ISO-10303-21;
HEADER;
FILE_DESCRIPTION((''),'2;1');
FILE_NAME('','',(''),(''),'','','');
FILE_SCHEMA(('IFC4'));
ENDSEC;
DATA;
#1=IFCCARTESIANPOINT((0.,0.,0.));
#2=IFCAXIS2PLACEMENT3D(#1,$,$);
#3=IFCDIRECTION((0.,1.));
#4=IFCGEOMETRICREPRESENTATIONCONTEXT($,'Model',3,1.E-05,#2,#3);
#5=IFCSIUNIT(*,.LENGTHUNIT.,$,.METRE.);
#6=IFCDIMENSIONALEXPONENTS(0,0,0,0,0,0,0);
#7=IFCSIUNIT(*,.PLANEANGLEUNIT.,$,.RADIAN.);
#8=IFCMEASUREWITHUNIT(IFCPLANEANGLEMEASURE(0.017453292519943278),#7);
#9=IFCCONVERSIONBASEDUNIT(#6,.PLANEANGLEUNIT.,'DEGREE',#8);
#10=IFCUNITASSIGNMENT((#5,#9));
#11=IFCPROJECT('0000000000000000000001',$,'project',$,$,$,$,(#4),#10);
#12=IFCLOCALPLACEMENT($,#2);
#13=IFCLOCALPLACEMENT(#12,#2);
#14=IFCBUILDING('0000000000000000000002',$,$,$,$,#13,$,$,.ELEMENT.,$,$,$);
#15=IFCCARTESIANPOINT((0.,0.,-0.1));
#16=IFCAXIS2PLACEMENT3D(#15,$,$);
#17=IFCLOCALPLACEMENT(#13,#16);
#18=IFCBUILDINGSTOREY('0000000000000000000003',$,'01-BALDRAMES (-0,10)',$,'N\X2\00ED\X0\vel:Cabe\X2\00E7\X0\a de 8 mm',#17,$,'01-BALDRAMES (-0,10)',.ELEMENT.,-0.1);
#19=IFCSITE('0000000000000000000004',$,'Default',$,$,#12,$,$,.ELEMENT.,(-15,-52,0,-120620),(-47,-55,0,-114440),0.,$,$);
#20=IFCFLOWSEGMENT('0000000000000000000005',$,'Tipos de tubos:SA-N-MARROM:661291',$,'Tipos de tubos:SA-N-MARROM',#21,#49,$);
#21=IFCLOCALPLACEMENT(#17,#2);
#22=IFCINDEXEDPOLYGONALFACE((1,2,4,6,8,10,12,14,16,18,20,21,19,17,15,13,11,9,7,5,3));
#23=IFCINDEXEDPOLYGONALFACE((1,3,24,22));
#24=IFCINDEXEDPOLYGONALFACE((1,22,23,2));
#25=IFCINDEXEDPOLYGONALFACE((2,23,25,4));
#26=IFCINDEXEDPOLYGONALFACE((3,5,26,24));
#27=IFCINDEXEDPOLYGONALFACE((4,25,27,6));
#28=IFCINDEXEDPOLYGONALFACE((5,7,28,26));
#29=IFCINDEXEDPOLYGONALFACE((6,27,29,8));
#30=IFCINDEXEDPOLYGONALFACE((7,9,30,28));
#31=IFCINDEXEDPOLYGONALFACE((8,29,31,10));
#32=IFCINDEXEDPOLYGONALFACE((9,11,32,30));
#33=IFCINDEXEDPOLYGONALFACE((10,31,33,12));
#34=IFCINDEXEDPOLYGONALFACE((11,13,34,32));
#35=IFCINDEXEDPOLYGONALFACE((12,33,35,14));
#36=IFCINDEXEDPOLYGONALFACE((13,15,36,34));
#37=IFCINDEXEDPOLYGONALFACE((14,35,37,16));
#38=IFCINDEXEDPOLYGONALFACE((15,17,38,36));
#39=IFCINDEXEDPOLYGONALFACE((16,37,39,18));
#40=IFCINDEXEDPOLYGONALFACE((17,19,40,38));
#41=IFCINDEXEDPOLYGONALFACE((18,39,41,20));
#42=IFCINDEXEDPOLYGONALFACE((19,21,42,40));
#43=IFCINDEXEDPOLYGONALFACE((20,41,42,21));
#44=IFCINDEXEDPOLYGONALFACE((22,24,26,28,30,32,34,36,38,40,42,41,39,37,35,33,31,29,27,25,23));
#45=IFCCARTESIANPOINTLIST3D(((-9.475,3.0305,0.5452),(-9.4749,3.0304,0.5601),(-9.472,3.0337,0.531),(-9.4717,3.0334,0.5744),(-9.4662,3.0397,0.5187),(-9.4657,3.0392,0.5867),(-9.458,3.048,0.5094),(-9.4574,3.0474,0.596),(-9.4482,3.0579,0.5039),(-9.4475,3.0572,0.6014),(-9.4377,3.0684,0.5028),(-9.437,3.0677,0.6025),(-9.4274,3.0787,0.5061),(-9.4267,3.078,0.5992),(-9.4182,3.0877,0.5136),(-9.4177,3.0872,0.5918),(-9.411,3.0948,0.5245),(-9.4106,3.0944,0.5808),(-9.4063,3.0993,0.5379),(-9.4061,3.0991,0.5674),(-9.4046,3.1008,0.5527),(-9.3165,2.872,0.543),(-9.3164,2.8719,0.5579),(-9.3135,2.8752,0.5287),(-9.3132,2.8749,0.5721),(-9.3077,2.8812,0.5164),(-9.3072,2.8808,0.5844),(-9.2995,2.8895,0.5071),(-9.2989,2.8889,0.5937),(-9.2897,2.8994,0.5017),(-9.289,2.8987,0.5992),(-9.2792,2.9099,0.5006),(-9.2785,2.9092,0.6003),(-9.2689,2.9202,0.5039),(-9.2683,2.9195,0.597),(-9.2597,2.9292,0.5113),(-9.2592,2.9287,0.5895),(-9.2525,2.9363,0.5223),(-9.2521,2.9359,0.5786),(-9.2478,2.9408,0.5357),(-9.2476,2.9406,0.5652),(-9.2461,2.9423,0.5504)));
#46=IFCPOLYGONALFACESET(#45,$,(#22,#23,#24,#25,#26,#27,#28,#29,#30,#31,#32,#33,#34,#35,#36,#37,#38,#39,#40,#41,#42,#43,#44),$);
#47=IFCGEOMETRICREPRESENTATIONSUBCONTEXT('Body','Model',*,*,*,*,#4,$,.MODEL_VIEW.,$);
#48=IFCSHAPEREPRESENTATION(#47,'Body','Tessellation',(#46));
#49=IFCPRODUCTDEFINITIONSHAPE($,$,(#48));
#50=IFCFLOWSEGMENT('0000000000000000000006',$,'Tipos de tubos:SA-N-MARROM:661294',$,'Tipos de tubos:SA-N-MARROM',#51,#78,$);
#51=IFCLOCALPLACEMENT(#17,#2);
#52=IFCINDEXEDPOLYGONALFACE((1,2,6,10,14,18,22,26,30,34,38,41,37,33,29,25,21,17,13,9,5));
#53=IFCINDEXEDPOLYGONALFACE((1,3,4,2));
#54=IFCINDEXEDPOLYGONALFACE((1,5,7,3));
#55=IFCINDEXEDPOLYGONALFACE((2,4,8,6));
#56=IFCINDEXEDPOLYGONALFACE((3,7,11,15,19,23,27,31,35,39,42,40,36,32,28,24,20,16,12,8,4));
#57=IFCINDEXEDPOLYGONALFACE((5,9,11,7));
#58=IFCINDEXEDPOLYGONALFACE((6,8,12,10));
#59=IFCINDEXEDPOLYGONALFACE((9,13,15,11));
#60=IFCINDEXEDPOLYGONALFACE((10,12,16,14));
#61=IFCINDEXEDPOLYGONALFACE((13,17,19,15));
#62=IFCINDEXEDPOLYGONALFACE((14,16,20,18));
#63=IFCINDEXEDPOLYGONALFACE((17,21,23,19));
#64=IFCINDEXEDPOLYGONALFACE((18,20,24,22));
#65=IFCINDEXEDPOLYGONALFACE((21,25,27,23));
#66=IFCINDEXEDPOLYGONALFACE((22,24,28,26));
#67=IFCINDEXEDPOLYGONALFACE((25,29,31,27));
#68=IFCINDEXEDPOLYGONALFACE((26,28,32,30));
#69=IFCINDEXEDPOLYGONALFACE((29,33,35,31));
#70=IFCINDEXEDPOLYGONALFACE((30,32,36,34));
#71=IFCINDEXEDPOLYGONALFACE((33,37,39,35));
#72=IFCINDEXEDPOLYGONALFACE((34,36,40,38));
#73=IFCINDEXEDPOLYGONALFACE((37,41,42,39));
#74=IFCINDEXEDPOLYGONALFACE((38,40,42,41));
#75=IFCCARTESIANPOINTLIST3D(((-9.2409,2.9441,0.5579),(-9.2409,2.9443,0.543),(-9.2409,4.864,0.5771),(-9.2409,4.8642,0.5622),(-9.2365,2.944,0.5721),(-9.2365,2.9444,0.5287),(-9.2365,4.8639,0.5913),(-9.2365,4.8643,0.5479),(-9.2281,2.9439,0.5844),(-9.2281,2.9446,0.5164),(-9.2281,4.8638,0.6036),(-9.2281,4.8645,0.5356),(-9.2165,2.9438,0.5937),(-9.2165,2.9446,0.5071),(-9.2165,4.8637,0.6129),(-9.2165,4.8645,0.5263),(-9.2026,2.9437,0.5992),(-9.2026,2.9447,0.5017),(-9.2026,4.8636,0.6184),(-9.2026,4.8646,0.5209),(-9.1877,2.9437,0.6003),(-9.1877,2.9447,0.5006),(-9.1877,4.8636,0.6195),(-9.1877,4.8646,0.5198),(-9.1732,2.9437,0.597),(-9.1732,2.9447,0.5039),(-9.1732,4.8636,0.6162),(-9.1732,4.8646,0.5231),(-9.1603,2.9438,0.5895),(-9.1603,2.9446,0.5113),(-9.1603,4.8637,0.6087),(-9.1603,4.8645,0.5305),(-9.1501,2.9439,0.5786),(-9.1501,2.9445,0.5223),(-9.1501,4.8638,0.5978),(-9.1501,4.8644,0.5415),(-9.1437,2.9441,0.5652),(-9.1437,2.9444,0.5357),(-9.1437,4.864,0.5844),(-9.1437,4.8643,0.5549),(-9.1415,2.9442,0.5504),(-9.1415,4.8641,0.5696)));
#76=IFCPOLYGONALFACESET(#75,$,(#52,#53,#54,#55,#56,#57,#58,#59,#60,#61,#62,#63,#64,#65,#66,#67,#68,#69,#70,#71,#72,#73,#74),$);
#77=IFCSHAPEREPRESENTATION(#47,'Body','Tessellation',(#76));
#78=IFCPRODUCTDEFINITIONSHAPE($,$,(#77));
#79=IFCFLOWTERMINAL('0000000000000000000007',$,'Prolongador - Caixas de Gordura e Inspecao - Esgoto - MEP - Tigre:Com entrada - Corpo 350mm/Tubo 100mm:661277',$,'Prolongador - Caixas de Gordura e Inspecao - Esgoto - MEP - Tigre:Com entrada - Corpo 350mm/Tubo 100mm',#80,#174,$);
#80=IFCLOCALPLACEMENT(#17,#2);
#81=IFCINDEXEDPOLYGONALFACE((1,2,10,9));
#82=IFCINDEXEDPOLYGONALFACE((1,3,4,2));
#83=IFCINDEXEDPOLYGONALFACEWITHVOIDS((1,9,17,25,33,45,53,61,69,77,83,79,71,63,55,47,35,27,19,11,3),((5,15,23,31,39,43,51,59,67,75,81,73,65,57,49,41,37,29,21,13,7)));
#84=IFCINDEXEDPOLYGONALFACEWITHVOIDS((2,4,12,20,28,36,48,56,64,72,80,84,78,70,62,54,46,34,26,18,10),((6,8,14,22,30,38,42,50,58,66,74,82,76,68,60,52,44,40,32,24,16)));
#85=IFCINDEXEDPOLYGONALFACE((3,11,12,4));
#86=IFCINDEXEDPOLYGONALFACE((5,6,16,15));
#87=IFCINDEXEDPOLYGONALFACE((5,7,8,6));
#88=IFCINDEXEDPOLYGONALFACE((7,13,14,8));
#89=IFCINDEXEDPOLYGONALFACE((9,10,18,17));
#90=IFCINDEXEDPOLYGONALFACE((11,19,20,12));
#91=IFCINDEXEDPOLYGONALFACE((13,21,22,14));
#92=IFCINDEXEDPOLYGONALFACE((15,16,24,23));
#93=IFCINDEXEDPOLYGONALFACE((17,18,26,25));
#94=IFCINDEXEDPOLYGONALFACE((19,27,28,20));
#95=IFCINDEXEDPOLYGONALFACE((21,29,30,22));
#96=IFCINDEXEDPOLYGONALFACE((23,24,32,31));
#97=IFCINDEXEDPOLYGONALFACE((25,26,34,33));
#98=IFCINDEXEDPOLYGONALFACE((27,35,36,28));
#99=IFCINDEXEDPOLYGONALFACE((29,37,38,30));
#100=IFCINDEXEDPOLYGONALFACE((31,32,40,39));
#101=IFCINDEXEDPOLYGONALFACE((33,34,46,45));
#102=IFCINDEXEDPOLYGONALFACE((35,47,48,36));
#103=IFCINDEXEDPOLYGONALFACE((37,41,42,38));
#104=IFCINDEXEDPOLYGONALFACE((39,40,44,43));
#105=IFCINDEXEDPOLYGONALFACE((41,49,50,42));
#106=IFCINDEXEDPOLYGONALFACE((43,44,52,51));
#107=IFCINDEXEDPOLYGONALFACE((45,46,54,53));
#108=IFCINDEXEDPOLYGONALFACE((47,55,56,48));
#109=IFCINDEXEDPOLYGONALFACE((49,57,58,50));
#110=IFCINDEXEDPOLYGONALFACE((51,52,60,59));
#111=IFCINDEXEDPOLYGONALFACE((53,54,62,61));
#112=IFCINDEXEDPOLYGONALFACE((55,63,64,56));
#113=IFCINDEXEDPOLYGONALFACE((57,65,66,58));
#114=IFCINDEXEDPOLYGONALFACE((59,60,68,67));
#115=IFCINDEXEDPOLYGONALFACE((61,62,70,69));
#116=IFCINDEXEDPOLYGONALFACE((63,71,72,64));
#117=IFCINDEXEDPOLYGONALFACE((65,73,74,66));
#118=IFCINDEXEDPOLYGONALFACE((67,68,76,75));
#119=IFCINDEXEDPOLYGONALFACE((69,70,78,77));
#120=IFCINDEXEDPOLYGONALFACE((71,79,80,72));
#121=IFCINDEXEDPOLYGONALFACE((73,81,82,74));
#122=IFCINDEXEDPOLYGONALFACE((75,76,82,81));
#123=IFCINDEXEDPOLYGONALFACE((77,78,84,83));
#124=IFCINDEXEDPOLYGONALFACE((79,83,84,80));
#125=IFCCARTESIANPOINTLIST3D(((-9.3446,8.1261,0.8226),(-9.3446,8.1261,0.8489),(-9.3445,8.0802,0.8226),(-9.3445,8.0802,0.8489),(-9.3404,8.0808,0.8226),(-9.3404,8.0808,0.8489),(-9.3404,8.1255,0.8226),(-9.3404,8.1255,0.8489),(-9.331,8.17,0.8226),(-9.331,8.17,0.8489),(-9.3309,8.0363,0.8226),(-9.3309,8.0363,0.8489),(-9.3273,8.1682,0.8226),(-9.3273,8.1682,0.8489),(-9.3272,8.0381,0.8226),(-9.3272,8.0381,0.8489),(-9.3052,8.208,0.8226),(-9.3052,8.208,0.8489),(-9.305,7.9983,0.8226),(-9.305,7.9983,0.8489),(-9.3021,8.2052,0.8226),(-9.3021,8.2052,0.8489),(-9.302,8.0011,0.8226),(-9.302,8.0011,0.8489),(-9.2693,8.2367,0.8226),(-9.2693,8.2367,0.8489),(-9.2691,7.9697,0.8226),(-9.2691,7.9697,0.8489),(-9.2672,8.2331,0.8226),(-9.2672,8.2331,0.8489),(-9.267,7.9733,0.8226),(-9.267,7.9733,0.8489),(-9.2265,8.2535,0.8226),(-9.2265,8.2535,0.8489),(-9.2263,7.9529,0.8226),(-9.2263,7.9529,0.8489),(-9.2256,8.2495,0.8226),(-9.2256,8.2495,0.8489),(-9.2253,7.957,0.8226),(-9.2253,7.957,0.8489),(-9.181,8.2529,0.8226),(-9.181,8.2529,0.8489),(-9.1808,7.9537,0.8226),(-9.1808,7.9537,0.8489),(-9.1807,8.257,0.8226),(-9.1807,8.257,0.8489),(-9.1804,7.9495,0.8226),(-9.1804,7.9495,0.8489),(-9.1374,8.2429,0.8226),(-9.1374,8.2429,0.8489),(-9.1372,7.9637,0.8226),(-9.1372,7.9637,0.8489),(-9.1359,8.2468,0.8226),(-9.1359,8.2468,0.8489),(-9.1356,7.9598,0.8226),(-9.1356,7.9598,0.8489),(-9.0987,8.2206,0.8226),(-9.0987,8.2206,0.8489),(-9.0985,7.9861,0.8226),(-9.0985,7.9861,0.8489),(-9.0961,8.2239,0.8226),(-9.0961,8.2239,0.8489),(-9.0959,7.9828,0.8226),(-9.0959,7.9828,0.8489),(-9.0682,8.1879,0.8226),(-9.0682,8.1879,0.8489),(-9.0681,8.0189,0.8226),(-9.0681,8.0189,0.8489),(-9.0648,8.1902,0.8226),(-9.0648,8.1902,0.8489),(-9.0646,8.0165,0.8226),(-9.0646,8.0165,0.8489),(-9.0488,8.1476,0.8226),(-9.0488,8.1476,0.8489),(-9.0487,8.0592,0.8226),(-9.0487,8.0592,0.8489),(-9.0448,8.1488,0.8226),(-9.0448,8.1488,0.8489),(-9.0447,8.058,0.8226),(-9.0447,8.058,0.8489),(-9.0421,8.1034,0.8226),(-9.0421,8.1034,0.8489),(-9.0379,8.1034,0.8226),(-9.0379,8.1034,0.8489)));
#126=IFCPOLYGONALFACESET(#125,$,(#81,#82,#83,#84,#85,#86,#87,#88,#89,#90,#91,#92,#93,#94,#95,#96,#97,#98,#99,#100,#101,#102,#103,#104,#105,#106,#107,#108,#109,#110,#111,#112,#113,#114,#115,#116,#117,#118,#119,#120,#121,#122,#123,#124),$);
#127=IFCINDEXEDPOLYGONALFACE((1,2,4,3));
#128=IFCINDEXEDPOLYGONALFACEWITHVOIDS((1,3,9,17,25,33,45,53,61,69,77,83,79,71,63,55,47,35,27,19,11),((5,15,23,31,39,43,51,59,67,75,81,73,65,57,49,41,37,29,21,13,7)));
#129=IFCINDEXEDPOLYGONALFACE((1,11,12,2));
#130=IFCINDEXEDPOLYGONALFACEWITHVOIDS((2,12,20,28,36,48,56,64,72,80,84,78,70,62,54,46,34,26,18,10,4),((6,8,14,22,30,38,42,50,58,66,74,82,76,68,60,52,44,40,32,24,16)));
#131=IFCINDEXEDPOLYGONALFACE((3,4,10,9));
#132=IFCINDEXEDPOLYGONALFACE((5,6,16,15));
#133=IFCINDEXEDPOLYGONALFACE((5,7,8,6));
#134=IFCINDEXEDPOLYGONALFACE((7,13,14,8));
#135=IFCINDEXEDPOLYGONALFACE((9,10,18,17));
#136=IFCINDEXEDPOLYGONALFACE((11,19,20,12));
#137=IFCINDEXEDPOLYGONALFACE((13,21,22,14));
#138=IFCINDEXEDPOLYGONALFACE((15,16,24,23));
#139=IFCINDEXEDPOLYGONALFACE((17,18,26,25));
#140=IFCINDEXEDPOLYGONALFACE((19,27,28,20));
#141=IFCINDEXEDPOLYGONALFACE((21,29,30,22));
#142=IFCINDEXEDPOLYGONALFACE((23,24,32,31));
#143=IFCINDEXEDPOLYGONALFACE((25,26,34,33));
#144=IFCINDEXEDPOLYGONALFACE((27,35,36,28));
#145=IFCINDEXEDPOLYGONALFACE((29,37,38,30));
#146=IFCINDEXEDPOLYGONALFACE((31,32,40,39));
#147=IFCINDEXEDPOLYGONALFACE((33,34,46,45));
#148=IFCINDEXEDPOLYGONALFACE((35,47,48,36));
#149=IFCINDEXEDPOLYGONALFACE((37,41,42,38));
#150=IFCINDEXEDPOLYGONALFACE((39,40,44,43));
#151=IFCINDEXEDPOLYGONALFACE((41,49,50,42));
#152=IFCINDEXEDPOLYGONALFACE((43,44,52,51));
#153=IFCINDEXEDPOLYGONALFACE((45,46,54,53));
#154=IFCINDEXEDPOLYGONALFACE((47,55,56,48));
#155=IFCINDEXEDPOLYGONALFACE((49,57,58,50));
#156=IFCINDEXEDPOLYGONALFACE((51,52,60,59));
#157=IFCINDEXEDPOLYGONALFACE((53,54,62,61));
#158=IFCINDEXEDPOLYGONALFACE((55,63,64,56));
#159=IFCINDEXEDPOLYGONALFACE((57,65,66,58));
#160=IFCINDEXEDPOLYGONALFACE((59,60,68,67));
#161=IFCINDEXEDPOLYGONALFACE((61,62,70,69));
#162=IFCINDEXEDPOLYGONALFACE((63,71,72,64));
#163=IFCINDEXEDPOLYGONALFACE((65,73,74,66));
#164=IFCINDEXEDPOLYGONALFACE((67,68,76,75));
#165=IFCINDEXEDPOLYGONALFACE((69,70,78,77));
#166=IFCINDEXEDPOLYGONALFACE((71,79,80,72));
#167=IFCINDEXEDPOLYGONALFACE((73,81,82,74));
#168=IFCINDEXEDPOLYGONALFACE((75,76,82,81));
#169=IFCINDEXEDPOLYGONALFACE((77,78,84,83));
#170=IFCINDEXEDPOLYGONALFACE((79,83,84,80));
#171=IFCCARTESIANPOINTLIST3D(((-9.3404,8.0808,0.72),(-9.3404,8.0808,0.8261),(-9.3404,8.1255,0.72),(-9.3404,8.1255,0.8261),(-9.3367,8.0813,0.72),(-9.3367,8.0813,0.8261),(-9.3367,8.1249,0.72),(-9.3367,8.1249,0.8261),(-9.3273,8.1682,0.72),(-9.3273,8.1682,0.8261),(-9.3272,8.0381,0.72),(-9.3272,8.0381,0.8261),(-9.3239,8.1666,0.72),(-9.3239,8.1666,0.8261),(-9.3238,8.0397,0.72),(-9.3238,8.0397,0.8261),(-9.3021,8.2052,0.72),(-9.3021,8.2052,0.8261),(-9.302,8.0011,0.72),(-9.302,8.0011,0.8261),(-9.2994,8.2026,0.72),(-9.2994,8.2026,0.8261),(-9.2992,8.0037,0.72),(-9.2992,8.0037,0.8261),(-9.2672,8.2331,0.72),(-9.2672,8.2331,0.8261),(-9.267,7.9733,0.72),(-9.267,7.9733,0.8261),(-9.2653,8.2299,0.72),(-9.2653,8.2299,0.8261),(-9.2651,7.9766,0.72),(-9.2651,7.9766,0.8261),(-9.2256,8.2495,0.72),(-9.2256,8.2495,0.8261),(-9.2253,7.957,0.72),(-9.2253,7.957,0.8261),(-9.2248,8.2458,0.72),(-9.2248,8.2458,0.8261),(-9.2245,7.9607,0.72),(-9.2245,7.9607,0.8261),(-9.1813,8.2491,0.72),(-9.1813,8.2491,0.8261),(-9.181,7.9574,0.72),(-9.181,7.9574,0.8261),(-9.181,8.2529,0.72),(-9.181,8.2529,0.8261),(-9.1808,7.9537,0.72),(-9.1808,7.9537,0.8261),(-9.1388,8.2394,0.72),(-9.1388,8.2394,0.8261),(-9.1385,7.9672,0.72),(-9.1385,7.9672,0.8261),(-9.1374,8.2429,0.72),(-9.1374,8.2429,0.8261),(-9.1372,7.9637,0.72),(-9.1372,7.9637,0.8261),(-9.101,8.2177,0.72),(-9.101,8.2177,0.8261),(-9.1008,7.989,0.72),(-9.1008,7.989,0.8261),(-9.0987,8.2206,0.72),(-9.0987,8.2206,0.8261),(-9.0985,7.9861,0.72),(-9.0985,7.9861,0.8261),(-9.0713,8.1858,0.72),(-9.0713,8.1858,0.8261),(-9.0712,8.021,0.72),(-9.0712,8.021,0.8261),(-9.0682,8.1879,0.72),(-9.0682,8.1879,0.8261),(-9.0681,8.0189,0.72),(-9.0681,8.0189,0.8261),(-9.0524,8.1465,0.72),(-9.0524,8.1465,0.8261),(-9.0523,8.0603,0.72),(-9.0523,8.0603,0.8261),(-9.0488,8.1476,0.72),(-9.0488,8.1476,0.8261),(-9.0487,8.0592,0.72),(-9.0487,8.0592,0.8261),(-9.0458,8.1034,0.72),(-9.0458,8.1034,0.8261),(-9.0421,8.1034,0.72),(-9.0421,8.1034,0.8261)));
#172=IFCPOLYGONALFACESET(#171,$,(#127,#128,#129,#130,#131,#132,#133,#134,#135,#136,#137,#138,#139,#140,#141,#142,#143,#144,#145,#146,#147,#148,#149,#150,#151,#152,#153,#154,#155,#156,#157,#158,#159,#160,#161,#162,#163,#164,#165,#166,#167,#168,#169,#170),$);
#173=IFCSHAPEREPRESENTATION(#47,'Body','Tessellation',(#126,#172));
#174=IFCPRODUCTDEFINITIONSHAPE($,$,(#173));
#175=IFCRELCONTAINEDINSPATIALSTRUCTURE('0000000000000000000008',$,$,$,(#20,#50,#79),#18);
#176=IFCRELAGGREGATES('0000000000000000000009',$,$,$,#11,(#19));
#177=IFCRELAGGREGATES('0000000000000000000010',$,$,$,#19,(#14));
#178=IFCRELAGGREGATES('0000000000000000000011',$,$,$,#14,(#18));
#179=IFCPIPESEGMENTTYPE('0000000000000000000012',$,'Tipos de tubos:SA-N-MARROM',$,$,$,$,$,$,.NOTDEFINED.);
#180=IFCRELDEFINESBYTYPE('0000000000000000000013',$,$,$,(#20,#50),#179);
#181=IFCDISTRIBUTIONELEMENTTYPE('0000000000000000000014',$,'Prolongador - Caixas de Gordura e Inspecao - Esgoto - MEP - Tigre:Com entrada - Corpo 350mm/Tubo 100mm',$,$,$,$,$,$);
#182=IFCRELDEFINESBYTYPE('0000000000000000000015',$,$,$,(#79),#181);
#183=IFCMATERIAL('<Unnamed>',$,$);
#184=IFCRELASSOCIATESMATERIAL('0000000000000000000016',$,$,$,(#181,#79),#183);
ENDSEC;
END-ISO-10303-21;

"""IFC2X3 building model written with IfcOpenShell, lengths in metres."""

from ifc_helpers import new_model, entity, si_unit, converted_unit, direction, frame, frame_2d, origin, place, context, subcontext, project, spatial, circle, hollow_circle, extrude, source, transform, mapped, material, type_object, type_shapes, element, save


model = new_model("IFC2X3")

# Units and contexts
model_context = context("Model", 3, precision=1e-05, world=origin(), true_north=direction((0.0, 1.0)))
body_context = subcontext(model_context, "Body", "Model", "MODEL_VIEW")
ifc_project = project(units=[si_unit("LENGTHUNIT", "METRE"), converted_unit("PLANEANGLEUNIT", "DEGREE", entity("IfcPlaneAngleMeasure", 0.017453292519943278), si_unit("PLANEANGLEUNIT", "RADIAN"), dimensions=[0, 0, 0, 0, 0, 0, 0])], contexts=[model_context])

# Site, building, storey
site_placement = place(None, origin())
site = spatial("IfcSite", under=ifc_project, at=site_placement, Name="Default", CompositionType="ELEMENT", RefLatitude=(-15, -52, 0, -120620), RefLongitude=(-47, -55, 0, -114440), RefElevation=0.0)
building_placement = place(site_placement, origin())
building = spatial("IfcBuilding", under=site, at=building_placement, CompositionType="ELEMENT")
storey_placement = place(building_placement, frame((0.0, 0.0, -0.1)))
storey = spatial("IfcBuildingStorey", under=building, at=storey_placement, Name="01-BALDRAMES (-0,10)", ObjectType="Nível:Cabeça de 8 mm", LongName="01-BALDRAMES (-0,10)", CompositionType="ELEMENT", Elevation=-0.1)

# Shared definitions
ifc_material = material(Name="<Unnamed>")

# Flow segments
pipe_segment_type_1 = type_object("IfcPipeSegmentType", Name="Tipos de tubos:SA-N-MARROM", PredefinedType="NOTDEFINED")
flow_segment_1_placement = place(storey_placement, origin())
element("IfcFlowSegment", 1, at=flow_segment_1_placement, inside=storey, type_object=pipe_segment_type_1, Name="Tipos de tubos:SA-N-MARROM:661291", ObjectType="Tipos de tubos:SA-N-MARROM", context=body_context, shape_type="SweptSolid", body=[
    extrude(circle(Radius=0.05, at=frame_2d((0.0, 0.0), x_axis=(1.0, 0.0))), frame((-9.44, 3.0654, 0.5527), z_axis=(0.707072, -0.707071, -0.01), x_axis=(0.707106, 0.707107, 0.0)), (0.0, 0.0, 1.0), 0.2242),
])
flow_segment_2_placement = place(storey_placement, origin())
element("IfcFlowSegment", 2, at=flow_segment_2_placement, inside=storey, type_object=pipe_segment_type_1, Name="Tipos de tubos:SA-N-MARROM:661294", ObjectType="Tipos de tubos:SA-N-MARROM", context=body_context, shape_type="SweptSolid", body=[
    extrude(circle(Radius=0.05, at=frame_2d((0.0, 0.0), x_axis=(1.0, 0.0))), frame((-9.1915, 2.9442, 0.5504), z_axis=(-0.000001, 0.99995, 0.01), x_axis=(1.0, 0.000001, 0.0)), (0.0, 0.0, 1.0), 1.92),
])

# Flow terminal
distribution_element_type_1 = type_object("IfcDistributionElementType", Name="Prolongador - Caixas de Gordura e Inspecao - Esgoto - MEP - Tigre:Com entrada - Corpo 350mm/Tubo 100mm", material=ifc_material)
shared_shape_1 = source(origin(), body_context, "Body", "SweptSolid", [
    extrude(hollow_circle(Radius=0.1542, WallThickness=0.0042, at=frame_2d((0.0, 0.0), x_axis=(1.0, 0.0))), frame((0.0, 0.0, -0.0574), z_axis=(0.0, 0.0, 1.0), x_axis=(0.0, -1.0, 0.0)), (0.0, 0.0, 1.0), 0.0263),
    extrude(hollow_circle(Radius=0.15, WallThickness=0.0038, at=frame_2d((0.0, 0.0), x_axis=(1.0, 0.0))), frame((0.0, 0.0, -0.16), z_axis=(0.0, 0.0, 1.0), x_axis=(0.0, -1.0, 0.0)), (0.0, 0.0, 1.0), 0.1061),
])
type_shapes(distribution_element_type_1, [shared_shape_1])
flow_terminal_1_placement = place(storey_placement, frame((-9.1921, 8.1033, 0.88), z_axis=(0.0, 0.0, 1.0), x_axis=(-0.000878, 1.0, 0.0)))
element("IfcFlowTerminal", 3, at=flow_terminal_1_placement, inside=storey, type_object=distribution_element_type_1, material=ifc_material, Name="Prolongador - Caixas de Gordura e Inspecao - Esgoto - MEP - Tigre:Com entrada - Corpo 350mm/Tubo 100mm:661277", ObjectType="Prolongador - Caixas de Gordura e Inspecao - Esgoto - MEP - Tigre:Com entrada - Corpo 350mm/Tubo 100mm", context=body_context, shape_type="MappedRepresentation", body=[
    mapped(shared_shape_1, transform((0.0, 0.0, 0.0), scale=1.0)),
])

save(model, "model.ifc")
